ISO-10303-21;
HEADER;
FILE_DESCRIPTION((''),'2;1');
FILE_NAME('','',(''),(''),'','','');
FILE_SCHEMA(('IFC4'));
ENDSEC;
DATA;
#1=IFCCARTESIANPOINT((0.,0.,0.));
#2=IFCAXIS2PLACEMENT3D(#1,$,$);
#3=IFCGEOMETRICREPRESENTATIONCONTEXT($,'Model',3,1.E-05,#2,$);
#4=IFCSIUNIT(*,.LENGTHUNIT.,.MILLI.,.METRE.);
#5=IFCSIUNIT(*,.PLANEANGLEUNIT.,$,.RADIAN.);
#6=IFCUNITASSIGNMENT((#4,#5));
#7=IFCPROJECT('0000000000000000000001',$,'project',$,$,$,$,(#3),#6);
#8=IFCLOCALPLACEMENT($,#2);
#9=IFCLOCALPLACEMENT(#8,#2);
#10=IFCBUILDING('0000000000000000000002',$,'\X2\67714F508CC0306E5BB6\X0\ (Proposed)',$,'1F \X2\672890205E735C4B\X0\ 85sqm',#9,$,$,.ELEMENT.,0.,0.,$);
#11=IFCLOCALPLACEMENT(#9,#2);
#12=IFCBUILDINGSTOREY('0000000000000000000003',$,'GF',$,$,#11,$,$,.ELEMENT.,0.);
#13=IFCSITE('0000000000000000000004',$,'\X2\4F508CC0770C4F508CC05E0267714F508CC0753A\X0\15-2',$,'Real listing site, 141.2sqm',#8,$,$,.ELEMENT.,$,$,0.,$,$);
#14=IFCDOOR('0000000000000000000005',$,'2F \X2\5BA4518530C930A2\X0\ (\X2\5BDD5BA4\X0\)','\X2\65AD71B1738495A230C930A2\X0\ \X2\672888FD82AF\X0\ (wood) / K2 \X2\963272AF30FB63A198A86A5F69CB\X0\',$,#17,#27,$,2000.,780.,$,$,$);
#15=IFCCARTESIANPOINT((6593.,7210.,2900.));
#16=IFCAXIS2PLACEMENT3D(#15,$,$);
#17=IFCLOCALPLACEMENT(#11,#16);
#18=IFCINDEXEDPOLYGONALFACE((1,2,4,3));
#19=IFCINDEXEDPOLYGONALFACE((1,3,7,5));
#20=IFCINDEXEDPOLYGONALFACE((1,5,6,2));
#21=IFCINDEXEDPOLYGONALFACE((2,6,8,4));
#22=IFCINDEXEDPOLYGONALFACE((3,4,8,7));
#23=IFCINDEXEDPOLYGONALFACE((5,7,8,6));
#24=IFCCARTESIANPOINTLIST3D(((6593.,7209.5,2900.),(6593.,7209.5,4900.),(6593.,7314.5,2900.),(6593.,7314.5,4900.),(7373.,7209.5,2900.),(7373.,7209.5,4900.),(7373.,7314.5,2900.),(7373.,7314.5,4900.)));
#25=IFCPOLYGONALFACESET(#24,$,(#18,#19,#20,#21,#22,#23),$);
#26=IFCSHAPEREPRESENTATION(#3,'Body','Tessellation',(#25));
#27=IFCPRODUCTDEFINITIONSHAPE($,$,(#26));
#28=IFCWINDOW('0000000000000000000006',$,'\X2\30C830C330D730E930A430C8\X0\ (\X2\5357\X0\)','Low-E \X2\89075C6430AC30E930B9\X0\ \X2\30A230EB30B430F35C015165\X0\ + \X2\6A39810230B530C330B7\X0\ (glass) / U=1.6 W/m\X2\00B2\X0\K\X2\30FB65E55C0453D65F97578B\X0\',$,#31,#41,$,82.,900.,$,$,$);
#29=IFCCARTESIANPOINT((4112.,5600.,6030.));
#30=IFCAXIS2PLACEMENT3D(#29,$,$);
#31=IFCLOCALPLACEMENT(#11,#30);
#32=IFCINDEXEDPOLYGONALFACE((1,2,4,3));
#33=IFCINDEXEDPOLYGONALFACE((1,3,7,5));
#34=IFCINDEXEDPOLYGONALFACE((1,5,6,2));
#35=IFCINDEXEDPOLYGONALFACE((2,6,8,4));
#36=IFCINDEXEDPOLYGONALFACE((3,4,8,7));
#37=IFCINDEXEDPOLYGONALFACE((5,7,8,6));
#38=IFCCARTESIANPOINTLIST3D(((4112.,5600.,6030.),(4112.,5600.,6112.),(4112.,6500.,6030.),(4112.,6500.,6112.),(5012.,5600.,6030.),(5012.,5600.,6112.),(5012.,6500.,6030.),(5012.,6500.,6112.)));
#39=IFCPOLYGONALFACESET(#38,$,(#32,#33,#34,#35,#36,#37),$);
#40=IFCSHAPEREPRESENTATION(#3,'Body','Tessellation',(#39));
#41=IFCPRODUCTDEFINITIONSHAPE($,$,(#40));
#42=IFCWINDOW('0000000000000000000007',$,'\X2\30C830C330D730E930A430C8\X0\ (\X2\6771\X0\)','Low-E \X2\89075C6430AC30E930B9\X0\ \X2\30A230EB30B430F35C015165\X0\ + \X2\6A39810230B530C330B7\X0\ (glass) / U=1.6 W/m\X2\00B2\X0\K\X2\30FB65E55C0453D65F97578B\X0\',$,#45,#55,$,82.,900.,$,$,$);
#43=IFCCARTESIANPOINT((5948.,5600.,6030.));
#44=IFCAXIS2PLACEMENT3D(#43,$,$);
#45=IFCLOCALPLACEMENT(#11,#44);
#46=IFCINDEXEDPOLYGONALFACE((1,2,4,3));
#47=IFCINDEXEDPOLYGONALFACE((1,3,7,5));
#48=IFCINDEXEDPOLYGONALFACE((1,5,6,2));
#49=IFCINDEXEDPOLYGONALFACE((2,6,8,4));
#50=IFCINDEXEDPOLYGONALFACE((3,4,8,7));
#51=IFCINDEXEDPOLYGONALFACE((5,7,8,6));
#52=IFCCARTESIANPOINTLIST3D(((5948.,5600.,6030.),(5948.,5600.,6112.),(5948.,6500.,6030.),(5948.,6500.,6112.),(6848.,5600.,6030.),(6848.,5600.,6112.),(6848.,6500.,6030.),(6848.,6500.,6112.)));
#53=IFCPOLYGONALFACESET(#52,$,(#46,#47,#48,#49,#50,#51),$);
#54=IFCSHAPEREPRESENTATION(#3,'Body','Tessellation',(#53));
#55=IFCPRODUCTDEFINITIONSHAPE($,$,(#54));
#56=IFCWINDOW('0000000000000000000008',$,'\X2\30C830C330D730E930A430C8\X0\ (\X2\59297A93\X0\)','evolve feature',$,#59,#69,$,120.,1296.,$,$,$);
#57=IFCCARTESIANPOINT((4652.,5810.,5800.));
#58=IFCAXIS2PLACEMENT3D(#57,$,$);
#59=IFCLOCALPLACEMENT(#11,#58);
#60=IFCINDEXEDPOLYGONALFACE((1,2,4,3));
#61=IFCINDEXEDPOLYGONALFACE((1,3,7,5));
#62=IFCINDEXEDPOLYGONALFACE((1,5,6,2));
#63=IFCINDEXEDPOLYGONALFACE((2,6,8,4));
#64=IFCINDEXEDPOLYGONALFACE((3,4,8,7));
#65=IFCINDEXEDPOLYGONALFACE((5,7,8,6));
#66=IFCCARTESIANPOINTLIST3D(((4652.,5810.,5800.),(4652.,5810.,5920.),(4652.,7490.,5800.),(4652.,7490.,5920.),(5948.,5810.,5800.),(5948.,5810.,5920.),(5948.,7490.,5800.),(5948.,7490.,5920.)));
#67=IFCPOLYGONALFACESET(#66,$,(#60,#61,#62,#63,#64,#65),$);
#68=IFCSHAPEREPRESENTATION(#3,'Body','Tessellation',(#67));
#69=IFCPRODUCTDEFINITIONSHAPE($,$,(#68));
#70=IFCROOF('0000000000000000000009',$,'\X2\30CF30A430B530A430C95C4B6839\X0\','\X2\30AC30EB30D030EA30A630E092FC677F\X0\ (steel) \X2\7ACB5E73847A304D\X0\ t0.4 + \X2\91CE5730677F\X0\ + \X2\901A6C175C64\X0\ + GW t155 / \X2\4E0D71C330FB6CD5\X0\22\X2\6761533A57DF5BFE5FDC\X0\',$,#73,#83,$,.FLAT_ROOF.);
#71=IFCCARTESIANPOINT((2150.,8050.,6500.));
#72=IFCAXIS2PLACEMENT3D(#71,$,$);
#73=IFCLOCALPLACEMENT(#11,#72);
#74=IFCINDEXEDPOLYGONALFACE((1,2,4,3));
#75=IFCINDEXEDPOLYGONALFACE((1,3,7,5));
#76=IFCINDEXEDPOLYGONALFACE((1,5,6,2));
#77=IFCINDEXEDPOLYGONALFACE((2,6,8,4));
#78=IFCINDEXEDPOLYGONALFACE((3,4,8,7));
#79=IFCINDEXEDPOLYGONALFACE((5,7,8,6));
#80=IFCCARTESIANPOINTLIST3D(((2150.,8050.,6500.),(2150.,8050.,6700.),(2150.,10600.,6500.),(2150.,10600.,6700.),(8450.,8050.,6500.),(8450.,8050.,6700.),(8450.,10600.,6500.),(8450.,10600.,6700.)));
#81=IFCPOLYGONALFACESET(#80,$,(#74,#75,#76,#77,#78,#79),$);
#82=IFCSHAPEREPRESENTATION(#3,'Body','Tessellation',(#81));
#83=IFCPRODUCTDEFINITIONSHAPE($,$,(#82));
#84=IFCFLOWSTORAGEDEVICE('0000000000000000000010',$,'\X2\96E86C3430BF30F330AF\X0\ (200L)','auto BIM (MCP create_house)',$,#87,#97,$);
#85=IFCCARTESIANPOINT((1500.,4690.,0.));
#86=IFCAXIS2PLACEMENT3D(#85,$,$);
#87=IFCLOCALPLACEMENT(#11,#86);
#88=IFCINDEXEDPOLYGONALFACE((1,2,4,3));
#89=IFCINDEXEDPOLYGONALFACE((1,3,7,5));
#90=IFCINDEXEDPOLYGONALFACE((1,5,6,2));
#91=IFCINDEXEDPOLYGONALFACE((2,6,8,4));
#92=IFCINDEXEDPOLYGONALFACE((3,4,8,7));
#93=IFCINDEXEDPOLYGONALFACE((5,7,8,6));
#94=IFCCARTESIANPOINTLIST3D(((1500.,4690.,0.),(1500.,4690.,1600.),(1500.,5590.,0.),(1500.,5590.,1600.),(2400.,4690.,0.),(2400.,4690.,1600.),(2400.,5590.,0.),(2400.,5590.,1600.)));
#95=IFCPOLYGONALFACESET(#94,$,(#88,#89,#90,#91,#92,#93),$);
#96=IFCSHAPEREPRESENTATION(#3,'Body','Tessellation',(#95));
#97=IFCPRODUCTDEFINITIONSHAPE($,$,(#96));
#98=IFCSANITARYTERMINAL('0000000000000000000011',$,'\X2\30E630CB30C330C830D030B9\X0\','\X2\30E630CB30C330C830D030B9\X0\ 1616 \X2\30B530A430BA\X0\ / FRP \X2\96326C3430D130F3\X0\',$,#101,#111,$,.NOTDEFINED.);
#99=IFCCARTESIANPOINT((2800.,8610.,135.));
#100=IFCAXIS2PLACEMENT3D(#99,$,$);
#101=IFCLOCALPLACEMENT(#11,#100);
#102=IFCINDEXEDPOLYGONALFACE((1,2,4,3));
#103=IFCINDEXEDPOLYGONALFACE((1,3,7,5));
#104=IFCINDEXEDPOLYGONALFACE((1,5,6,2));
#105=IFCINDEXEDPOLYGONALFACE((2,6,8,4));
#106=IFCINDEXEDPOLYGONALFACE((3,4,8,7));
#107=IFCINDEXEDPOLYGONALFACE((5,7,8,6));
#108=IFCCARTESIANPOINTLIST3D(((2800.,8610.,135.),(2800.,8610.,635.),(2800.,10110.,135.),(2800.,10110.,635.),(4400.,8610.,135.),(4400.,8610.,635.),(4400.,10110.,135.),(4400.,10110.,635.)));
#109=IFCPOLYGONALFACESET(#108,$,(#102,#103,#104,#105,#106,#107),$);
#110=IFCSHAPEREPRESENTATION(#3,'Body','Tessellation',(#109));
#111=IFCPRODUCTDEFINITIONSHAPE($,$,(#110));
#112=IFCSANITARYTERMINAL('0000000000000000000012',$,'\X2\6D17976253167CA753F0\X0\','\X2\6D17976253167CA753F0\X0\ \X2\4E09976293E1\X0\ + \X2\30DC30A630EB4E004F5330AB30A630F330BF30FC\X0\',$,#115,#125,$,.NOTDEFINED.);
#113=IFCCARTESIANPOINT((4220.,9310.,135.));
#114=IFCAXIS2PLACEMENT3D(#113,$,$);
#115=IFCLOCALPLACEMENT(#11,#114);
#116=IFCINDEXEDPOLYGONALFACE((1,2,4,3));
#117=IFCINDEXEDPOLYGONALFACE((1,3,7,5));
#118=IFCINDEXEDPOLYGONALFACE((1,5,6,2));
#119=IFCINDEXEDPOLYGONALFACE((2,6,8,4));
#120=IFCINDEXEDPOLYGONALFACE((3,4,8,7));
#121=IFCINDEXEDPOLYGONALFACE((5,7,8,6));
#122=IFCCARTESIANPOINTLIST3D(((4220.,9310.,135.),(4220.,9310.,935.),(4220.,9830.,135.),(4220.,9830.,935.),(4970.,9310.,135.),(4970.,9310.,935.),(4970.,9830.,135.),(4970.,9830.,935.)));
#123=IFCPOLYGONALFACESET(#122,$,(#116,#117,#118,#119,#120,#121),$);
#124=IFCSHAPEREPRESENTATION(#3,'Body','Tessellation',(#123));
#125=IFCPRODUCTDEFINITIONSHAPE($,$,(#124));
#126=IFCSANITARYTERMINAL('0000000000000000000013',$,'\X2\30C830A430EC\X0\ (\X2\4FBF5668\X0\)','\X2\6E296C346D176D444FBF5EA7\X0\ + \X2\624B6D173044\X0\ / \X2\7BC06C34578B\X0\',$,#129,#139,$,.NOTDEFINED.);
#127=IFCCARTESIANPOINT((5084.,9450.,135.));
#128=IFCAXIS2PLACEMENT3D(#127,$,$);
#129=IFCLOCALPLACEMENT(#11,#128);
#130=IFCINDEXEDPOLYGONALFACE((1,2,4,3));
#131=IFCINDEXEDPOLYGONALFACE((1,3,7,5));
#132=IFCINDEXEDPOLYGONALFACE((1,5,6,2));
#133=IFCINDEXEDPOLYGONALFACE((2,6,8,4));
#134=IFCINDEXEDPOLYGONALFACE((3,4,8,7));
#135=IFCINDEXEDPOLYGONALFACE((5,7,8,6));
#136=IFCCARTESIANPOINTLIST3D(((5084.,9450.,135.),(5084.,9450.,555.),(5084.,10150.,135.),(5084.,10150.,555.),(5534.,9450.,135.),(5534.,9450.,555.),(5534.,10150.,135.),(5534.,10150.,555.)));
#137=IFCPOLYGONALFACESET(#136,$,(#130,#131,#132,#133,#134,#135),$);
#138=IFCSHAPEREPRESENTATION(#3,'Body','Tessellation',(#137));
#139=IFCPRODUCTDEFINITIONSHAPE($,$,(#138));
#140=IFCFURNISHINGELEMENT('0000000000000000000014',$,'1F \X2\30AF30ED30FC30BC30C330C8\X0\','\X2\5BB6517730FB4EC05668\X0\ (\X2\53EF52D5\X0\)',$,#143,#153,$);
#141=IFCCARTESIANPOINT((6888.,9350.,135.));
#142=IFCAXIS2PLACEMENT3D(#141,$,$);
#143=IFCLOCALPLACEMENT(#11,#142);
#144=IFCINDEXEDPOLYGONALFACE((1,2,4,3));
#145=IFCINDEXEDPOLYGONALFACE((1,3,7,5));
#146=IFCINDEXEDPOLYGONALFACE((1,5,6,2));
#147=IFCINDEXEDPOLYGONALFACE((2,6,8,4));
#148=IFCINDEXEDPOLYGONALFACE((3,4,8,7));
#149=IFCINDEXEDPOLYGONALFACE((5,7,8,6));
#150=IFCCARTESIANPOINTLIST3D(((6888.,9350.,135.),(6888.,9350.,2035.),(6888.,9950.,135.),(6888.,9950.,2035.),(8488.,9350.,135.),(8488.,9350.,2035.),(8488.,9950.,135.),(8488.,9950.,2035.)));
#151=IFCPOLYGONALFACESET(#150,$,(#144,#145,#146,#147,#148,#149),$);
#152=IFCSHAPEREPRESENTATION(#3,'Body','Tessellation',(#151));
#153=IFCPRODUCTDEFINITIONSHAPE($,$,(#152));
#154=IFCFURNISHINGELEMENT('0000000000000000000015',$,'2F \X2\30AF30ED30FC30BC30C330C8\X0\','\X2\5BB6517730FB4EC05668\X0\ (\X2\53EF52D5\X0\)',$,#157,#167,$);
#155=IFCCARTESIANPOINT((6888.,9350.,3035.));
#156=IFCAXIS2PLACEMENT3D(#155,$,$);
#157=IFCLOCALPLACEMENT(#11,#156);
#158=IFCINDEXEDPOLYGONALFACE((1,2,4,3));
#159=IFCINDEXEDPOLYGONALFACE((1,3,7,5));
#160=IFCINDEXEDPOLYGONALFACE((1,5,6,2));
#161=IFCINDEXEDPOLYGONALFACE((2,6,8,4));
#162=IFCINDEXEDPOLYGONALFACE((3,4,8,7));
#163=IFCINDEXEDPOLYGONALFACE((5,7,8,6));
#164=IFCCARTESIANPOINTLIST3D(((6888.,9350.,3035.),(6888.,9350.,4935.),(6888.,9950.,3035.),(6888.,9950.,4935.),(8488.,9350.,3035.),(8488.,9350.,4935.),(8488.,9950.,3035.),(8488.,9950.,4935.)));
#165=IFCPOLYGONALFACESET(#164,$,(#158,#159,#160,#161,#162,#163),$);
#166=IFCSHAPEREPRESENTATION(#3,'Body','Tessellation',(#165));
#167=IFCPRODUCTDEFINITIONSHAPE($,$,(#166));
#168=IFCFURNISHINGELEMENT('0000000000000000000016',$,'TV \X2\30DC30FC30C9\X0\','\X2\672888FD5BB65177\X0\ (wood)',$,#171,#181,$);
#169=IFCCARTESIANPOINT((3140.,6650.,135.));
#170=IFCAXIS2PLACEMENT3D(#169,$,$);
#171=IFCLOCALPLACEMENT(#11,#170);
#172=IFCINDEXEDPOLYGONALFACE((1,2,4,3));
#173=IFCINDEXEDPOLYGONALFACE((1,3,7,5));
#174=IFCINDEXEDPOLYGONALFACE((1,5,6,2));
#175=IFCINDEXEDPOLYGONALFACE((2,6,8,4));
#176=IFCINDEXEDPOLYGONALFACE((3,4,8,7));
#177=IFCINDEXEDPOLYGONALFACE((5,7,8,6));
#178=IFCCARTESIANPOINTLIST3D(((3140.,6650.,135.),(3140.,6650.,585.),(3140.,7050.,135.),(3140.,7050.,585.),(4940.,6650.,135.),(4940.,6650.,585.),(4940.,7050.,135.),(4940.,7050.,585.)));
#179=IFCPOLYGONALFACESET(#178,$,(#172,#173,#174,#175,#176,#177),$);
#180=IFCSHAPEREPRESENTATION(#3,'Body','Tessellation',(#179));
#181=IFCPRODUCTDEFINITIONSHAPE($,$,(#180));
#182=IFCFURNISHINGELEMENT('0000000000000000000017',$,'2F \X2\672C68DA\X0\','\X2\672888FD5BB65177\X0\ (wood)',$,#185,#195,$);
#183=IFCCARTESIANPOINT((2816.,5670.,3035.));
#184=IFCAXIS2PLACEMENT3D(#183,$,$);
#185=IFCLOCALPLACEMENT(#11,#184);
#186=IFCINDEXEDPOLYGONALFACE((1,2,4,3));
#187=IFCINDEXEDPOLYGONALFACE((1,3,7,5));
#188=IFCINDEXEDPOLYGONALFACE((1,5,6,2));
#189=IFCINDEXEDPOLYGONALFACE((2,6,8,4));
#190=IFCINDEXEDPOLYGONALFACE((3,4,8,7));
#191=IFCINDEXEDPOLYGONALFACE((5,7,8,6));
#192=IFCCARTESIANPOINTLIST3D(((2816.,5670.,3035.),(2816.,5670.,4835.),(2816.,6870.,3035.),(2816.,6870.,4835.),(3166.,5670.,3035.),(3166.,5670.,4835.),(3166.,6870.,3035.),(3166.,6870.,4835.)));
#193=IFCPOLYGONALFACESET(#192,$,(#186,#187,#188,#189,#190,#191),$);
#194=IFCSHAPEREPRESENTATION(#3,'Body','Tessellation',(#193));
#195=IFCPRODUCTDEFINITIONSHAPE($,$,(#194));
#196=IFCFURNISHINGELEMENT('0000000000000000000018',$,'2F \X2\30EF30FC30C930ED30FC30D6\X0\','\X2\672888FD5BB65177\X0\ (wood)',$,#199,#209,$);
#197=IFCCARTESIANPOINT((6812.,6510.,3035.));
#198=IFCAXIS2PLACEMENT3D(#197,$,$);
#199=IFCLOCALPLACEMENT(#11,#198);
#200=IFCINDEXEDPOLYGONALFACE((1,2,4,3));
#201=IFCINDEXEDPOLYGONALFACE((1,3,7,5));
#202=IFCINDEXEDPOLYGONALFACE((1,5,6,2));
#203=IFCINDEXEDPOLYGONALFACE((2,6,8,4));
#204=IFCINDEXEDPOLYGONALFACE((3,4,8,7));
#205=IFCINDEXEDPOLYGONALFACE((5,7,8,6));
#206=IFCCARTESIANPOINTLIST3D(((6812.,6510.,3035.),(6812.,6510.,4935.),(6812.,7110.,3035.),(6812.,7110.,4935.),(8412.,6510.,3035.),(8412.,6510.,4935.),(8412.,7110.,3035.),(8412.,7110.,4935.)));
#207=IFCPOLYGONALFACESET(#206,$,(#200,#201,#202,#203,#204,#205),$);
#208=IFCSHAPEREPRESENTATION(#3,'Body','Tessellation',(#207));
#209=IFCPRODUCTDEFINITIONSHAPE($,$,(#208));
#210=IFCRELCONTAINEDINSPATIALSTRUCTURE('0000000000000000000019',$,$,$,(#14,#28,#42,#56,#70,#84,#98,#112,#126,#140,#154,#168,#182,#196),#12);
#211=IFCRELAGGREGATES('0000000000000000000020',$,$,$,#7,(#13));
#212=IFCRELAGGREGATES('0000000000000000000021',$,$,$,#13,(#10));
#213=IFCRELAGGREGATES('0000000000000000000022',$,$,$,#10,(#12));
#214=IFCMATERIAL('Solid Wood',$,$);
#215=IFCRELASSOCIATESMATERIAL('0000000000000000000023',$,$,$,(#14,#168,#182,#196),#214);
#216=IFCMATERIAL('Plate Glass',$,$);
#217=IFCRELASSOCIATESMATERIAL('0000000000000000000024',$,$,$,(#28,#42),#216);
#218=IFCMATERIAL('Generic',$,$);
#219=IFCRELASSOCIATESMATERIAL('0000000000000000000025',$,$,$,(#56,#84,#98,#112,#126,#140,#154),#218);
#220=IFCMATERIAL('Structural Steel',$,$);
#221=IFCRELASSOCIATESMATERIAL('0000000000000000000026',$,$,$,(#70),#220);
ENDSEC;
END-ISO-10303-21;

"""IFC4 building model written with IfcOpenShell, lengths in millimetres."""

from ifc_helpers import new_model, si_unit, frame, frame_2d, origin, place, context, project, spatial, rectangle, extrude, material, element, save


model = new_model("IFC4")

# Units and contexts
model_context = context("Model", 3, precision=1e-05, world=origin())
ifc_project = project(units=[si_unit("LENGTHUNIT", "METRE", prefix="MILLI"), si_unit("PLANEANGLEUNIT", "RADIAN")], contexts=[model_context])

# Site, building, storey
site_placement = place(None, origin())
site = spatial("IfcSite", under=ifc_project, at=site_placement, Name="佐賀県佐賀市東佐賀町15-2", ObjectType="Real listing site, 141.2sqm", CompositionType="ELEMENT", RefElevation=0.0)
building_placement = place(site_placement, origin())
building = spatial("IfcBuilding", under=site, at=building_placement, Name="東佐賀の家 (Proposed)", ObjectType="1F 木造平屋 85sqm", CompositionType="ELEMENT", ElevationOfRefHeight=0.0, ElevationOfTerrain=0.0)
storey_placement = place(building_placement, origin())
storey = spatial("IfcBuildingStorey", under=building, at=storey_placement, Name="GF", CompositionType="ELEMENT", Elevation=0.0)

# Shared definitions
ifc_material_1 = material(Name="Solid Wood")
ifc_material_2 = material(Name="Plate Glass")

# Door
door_1_placement = place(storey_placement, frame((6593.0, 7210.0, 2900.0)))
element("IfcDoor", 1, at=door_1_placement, inside=storey, material=ifc_material_1, Name="2F 室内ドア (寝室)", Description="断熱玄関ドア 木製芯 (wood) / K2 防犯・採風機構", OverallHeight=2000.0, OverallWidth=780.0, context=model_context, shape_type="SweptSolid", body=[
    extrude(rectangle(XDim=780.0, YDim=105.0, at=frame_2d((390.0, 52.0))), frame((6593.0, 7210.0, 2900.0)), (0.0, 0.0, 1.0), 2000.0),
])

# Windows
window_1_placement = place(storey_placement, frame((4112.0, 5600.0, 6030.0)))
element("IfcWindow", 2, at=window_1_placement, inside=storey, material=ifc_material_2, Name="トップライト (南)", Description="Low-E 複層ガラス アルゴン封入 + 樹脂サッシ (glass) / U=1.6 W/m²K・日射取得型", OverallHeight=82.0, OverallWidth=900.0, context=model_context, shape_type="SweptSolid", body=[
    extrude(rectangle(XDim=900.0, YDim=900.0, at=frame_2d((450.0, 450.0))), frame((4112.0, 5600.0, 6030.0)), (0.0, 0.0, 1.0), 82.0),
])
window_2_placement = place(storey_placement, frame((5948.0, 5600.0, 6030.0)))
element("IfcWindow", 3, at=window_2_placement, inside=storey, material=ifc_material_2, Name="トップライト (東)", Description="Low-E 複層ガラス アルゴン封入 + 樹脂サッシ (glass) / U=1.6 W/m²K・日射取得型", OverallHeight=82.0, OverallWidth=900.0, context=model_context, shape_type="SweptSolid", body=[
    extrude(rectangle(XDim=900.0, YDim=900.0, at=frame_2d((450.0, 450.0))), frame((5948.0, 5600.0, 6030.0)), (0.0, 0.0, 1.0), 82.0),
])
ifc_material_3 = material(Name="Generic")
window_3_placement = place(storey_placement, frame((4652.0, 5810.0, 5800.0)))
element("IfcWindow", 4, at=window_3_placement, inside=storey, material=ifc_material_3, Name="トップライト (天窓)", Description="evolve feature", OverallHeight=120.0, OverallWidth=1296.0, context=model_context, shape_type="SweptSolid", body=[
    extrude(rectangle(XDim=1296.0, YDim=1680.0, at=frame_2d((648.0, 840.0))), frame((4652.0, 5810.0, 5800.0)), (0.0, 0.0, 1.0), 120.0),
])

# Roof
ifc_material_4 = material(Name="Structural Steel")
roof_placement = place(storey_placement, frame((2150.0, 8050.0, 6500.0)))
element("IfcRoof", 5, at=roof_placement, inside=storey, material=ifc_material_4, Name="ハイサイド屋根", Description="ガルバリウム鋼板 (steel) 立平葺き t0.4 + 野地板 + 通気層 + GW t155 / 不燃・法22条区域対応", PredefinedType="FLAT_ROOF", context=model_context, shape_type="SweptSolid", body=[
    extrude(rectangle(XDim=6300.0, YDim=2550.0, at=frame_2d((3150.0, 1275.0))), frame((2150.0, 8050.0, 6500.0)), (0.0, 0.0, 1.0), 200.0),
])

# Flow storage device
flow_storage_device_placement = place(storey_placement, frame((1500.0, 4690.0, 0.0)))
element("IfcFlowStorageDevice", 6, at=flow_storage_device_placement, inside=storey, material=ifc_material_3, Name="雨水タンク (200L)", Description="auto BIM (MCP create_house)", context=model_context, shape_type="SweptSolid", body=[
    extrude(rectangle(XDim=900.0, YDim=900.0, at=frame_2d((450.0, 450.0))), frame((1500.0, 4690.0, 0.0)), (0.0, 0.0, 1.0), 1600.0),
])

# Sanitary terminals
sanitary_terminal_1_placement = place(storey_placement, frame((2800.0, 8610.0, 135.0)))
element("IfcSanitaryTerminal", 7, at=sanitary_terminal_1_placement, inside=storey, material=ifc_material_3, Name="ユニットバス", Description="ユニットバス 1616 サイズ / FRP 防水パン", PredefinedType="NOTDEFINED", context=model_context, shape_type="SweptSolid", body=[
    extrude(rectangle(XDim=1600.0, YDim=1500.0, at=frame_2d((800.0, 750.0))), frame((2800.0, 8610.0, 135.0)), (0.0, 0.0, 1.0), 500.0),
])
sanitary_terminal_2_placement = place(storey_placement, frame((4220.0, 9310.0, 135.0)))
element("IfcSanitaryTerminal", 8, at=sanitary_terminal_2_placement, inside=storey, material=ifc_material_3, Name="洗面化粧台", Description="洗面化粧台 三面鏡 + ボウル一体カウンター", PredefinedType="NOTDEFINED", context=model_context, shape_type="SweptSolid", body=[
    extrude(rectangle(XDim=750.0, YDim=520.0, at=frame_2d((375.0, 260.0))), frame((4220.0, 9310.0, 135.0)), (0.0, 0.0, 1.0), 800.0),
])
sanitary_terminal_3_placement = place(storey_placement, frame((5084.0, 9450.0, 135.0)))
element("IfcSanitaryTerminal", 9, at=sanitary_terminal_3_placement, inside=storey, material=ifc_material_3, Name="トイレ (便器)", Description="温水洗浄便座 + 手洗い / 節水型", PredefinedType="NOTDEFINED", context=model_context, shape_type="SweptSolid", body=[
    extrude(rectangle(XDim=450.0, YDim=700.0, at=frame_2d((225.0, 350.0))), frame((5084.0, 9450.0, 135.0)), (0.0, 0.0, 1.0), 420.0),
])

# Furnishing elements
furnishing_1_placement = place(storey_placement, frame((6888.0, 9350.0, 135.0)))
element("IfcFurnishingElement", 10, at=furnishing_1_placement, inside=storey, material=ifc_material_3, Name="1F クローゼット", Description="家具・什器 (可動)", context=model_context, shape_type="SweptSolid", body=[
    extrude(rectangle(XDim=1600.0, YDim=600.0, at=frame_2d((800.0, 300.0))), frame((6888.0, 9350.0, 135.0)), (0.0, 0.0, 1.0), 1900.0),
])
furnishing_2_placement = place(storey_placement, frame((6888.0, 9350.0, 3035.0)))
element("IfcFurnishingElement", 11, at=furnishing_2_placement, inside=storey, material=ifc_material_3, Name="2F クローゼット", Description="家具・什器 (可動)", context=model_context, shape_type="SweptSolid", body=[
    extrude(rectangle(XDim=1600.0, YDim=600.0, at=frame_2d((800.0, 300.0))), frame((6888.0, 9350.0, 3035.0)), (0.0, 0.0, 1.0), 1900.0),
])
furnishing_3_placement = place(storey_placement, frame((3140.0, 6650.0, 135.0)))
element("IfcFurnishingElement", 12, at=furnishing_3_placement, inside=storey, material=ifc_material_1, Name="TV ボード", Description="木製家具 (wood)", context=model_context, shape_type="SweptSolid", body=[
    extrude(rectangle(XDim=1800.0, YDim=400.0, at=frame_2d((900.0, 200.0))), frame((3140.0, 6650.0, 135.0)), (0.0, 0.0, 1.0), 450.0),
])
furnishing_4_placement = place(storey_placement, frame((2816.0, 5670.0, 3035.0)))
element("IfcFurnishingElement", 13, at=furnishing_4_placement, inside=storey, material=ifc_material_1, Name="2F 本棚", Description="木製家具 (wood)", context=model_context, shape_type="SweptSolid", body=[
    extrude(rectangle(XDim=350.0, YDim=1200.0, at=frame_2d((175.0, 600.0))), frame((2816.0, 5670.0, 3035.0)), (0.0, 0.0, 1.0), 1800.0),
])
furnishing_5_placement = place(storey_placement, frame((6812.0, 6510.0, 3035.0)))
element("IfcFurnishingElement", 14, at=furnishing_5_placement, inside=storey, material=ifc_material_1, Name="2F ワードローブ", Description="木製家具 (wood)", context=model_context, shape_type="SweptSolid", body=[
    extrude(rectangle(XDim=1600.0, YDim=600.0, at=frame_2d((800.0, 300.0))), frame((6812.0, 6510.0, 3035.0)), (0.0, 0.0, 1.0), 1900.0),
])

save(model, "model.ifc")
